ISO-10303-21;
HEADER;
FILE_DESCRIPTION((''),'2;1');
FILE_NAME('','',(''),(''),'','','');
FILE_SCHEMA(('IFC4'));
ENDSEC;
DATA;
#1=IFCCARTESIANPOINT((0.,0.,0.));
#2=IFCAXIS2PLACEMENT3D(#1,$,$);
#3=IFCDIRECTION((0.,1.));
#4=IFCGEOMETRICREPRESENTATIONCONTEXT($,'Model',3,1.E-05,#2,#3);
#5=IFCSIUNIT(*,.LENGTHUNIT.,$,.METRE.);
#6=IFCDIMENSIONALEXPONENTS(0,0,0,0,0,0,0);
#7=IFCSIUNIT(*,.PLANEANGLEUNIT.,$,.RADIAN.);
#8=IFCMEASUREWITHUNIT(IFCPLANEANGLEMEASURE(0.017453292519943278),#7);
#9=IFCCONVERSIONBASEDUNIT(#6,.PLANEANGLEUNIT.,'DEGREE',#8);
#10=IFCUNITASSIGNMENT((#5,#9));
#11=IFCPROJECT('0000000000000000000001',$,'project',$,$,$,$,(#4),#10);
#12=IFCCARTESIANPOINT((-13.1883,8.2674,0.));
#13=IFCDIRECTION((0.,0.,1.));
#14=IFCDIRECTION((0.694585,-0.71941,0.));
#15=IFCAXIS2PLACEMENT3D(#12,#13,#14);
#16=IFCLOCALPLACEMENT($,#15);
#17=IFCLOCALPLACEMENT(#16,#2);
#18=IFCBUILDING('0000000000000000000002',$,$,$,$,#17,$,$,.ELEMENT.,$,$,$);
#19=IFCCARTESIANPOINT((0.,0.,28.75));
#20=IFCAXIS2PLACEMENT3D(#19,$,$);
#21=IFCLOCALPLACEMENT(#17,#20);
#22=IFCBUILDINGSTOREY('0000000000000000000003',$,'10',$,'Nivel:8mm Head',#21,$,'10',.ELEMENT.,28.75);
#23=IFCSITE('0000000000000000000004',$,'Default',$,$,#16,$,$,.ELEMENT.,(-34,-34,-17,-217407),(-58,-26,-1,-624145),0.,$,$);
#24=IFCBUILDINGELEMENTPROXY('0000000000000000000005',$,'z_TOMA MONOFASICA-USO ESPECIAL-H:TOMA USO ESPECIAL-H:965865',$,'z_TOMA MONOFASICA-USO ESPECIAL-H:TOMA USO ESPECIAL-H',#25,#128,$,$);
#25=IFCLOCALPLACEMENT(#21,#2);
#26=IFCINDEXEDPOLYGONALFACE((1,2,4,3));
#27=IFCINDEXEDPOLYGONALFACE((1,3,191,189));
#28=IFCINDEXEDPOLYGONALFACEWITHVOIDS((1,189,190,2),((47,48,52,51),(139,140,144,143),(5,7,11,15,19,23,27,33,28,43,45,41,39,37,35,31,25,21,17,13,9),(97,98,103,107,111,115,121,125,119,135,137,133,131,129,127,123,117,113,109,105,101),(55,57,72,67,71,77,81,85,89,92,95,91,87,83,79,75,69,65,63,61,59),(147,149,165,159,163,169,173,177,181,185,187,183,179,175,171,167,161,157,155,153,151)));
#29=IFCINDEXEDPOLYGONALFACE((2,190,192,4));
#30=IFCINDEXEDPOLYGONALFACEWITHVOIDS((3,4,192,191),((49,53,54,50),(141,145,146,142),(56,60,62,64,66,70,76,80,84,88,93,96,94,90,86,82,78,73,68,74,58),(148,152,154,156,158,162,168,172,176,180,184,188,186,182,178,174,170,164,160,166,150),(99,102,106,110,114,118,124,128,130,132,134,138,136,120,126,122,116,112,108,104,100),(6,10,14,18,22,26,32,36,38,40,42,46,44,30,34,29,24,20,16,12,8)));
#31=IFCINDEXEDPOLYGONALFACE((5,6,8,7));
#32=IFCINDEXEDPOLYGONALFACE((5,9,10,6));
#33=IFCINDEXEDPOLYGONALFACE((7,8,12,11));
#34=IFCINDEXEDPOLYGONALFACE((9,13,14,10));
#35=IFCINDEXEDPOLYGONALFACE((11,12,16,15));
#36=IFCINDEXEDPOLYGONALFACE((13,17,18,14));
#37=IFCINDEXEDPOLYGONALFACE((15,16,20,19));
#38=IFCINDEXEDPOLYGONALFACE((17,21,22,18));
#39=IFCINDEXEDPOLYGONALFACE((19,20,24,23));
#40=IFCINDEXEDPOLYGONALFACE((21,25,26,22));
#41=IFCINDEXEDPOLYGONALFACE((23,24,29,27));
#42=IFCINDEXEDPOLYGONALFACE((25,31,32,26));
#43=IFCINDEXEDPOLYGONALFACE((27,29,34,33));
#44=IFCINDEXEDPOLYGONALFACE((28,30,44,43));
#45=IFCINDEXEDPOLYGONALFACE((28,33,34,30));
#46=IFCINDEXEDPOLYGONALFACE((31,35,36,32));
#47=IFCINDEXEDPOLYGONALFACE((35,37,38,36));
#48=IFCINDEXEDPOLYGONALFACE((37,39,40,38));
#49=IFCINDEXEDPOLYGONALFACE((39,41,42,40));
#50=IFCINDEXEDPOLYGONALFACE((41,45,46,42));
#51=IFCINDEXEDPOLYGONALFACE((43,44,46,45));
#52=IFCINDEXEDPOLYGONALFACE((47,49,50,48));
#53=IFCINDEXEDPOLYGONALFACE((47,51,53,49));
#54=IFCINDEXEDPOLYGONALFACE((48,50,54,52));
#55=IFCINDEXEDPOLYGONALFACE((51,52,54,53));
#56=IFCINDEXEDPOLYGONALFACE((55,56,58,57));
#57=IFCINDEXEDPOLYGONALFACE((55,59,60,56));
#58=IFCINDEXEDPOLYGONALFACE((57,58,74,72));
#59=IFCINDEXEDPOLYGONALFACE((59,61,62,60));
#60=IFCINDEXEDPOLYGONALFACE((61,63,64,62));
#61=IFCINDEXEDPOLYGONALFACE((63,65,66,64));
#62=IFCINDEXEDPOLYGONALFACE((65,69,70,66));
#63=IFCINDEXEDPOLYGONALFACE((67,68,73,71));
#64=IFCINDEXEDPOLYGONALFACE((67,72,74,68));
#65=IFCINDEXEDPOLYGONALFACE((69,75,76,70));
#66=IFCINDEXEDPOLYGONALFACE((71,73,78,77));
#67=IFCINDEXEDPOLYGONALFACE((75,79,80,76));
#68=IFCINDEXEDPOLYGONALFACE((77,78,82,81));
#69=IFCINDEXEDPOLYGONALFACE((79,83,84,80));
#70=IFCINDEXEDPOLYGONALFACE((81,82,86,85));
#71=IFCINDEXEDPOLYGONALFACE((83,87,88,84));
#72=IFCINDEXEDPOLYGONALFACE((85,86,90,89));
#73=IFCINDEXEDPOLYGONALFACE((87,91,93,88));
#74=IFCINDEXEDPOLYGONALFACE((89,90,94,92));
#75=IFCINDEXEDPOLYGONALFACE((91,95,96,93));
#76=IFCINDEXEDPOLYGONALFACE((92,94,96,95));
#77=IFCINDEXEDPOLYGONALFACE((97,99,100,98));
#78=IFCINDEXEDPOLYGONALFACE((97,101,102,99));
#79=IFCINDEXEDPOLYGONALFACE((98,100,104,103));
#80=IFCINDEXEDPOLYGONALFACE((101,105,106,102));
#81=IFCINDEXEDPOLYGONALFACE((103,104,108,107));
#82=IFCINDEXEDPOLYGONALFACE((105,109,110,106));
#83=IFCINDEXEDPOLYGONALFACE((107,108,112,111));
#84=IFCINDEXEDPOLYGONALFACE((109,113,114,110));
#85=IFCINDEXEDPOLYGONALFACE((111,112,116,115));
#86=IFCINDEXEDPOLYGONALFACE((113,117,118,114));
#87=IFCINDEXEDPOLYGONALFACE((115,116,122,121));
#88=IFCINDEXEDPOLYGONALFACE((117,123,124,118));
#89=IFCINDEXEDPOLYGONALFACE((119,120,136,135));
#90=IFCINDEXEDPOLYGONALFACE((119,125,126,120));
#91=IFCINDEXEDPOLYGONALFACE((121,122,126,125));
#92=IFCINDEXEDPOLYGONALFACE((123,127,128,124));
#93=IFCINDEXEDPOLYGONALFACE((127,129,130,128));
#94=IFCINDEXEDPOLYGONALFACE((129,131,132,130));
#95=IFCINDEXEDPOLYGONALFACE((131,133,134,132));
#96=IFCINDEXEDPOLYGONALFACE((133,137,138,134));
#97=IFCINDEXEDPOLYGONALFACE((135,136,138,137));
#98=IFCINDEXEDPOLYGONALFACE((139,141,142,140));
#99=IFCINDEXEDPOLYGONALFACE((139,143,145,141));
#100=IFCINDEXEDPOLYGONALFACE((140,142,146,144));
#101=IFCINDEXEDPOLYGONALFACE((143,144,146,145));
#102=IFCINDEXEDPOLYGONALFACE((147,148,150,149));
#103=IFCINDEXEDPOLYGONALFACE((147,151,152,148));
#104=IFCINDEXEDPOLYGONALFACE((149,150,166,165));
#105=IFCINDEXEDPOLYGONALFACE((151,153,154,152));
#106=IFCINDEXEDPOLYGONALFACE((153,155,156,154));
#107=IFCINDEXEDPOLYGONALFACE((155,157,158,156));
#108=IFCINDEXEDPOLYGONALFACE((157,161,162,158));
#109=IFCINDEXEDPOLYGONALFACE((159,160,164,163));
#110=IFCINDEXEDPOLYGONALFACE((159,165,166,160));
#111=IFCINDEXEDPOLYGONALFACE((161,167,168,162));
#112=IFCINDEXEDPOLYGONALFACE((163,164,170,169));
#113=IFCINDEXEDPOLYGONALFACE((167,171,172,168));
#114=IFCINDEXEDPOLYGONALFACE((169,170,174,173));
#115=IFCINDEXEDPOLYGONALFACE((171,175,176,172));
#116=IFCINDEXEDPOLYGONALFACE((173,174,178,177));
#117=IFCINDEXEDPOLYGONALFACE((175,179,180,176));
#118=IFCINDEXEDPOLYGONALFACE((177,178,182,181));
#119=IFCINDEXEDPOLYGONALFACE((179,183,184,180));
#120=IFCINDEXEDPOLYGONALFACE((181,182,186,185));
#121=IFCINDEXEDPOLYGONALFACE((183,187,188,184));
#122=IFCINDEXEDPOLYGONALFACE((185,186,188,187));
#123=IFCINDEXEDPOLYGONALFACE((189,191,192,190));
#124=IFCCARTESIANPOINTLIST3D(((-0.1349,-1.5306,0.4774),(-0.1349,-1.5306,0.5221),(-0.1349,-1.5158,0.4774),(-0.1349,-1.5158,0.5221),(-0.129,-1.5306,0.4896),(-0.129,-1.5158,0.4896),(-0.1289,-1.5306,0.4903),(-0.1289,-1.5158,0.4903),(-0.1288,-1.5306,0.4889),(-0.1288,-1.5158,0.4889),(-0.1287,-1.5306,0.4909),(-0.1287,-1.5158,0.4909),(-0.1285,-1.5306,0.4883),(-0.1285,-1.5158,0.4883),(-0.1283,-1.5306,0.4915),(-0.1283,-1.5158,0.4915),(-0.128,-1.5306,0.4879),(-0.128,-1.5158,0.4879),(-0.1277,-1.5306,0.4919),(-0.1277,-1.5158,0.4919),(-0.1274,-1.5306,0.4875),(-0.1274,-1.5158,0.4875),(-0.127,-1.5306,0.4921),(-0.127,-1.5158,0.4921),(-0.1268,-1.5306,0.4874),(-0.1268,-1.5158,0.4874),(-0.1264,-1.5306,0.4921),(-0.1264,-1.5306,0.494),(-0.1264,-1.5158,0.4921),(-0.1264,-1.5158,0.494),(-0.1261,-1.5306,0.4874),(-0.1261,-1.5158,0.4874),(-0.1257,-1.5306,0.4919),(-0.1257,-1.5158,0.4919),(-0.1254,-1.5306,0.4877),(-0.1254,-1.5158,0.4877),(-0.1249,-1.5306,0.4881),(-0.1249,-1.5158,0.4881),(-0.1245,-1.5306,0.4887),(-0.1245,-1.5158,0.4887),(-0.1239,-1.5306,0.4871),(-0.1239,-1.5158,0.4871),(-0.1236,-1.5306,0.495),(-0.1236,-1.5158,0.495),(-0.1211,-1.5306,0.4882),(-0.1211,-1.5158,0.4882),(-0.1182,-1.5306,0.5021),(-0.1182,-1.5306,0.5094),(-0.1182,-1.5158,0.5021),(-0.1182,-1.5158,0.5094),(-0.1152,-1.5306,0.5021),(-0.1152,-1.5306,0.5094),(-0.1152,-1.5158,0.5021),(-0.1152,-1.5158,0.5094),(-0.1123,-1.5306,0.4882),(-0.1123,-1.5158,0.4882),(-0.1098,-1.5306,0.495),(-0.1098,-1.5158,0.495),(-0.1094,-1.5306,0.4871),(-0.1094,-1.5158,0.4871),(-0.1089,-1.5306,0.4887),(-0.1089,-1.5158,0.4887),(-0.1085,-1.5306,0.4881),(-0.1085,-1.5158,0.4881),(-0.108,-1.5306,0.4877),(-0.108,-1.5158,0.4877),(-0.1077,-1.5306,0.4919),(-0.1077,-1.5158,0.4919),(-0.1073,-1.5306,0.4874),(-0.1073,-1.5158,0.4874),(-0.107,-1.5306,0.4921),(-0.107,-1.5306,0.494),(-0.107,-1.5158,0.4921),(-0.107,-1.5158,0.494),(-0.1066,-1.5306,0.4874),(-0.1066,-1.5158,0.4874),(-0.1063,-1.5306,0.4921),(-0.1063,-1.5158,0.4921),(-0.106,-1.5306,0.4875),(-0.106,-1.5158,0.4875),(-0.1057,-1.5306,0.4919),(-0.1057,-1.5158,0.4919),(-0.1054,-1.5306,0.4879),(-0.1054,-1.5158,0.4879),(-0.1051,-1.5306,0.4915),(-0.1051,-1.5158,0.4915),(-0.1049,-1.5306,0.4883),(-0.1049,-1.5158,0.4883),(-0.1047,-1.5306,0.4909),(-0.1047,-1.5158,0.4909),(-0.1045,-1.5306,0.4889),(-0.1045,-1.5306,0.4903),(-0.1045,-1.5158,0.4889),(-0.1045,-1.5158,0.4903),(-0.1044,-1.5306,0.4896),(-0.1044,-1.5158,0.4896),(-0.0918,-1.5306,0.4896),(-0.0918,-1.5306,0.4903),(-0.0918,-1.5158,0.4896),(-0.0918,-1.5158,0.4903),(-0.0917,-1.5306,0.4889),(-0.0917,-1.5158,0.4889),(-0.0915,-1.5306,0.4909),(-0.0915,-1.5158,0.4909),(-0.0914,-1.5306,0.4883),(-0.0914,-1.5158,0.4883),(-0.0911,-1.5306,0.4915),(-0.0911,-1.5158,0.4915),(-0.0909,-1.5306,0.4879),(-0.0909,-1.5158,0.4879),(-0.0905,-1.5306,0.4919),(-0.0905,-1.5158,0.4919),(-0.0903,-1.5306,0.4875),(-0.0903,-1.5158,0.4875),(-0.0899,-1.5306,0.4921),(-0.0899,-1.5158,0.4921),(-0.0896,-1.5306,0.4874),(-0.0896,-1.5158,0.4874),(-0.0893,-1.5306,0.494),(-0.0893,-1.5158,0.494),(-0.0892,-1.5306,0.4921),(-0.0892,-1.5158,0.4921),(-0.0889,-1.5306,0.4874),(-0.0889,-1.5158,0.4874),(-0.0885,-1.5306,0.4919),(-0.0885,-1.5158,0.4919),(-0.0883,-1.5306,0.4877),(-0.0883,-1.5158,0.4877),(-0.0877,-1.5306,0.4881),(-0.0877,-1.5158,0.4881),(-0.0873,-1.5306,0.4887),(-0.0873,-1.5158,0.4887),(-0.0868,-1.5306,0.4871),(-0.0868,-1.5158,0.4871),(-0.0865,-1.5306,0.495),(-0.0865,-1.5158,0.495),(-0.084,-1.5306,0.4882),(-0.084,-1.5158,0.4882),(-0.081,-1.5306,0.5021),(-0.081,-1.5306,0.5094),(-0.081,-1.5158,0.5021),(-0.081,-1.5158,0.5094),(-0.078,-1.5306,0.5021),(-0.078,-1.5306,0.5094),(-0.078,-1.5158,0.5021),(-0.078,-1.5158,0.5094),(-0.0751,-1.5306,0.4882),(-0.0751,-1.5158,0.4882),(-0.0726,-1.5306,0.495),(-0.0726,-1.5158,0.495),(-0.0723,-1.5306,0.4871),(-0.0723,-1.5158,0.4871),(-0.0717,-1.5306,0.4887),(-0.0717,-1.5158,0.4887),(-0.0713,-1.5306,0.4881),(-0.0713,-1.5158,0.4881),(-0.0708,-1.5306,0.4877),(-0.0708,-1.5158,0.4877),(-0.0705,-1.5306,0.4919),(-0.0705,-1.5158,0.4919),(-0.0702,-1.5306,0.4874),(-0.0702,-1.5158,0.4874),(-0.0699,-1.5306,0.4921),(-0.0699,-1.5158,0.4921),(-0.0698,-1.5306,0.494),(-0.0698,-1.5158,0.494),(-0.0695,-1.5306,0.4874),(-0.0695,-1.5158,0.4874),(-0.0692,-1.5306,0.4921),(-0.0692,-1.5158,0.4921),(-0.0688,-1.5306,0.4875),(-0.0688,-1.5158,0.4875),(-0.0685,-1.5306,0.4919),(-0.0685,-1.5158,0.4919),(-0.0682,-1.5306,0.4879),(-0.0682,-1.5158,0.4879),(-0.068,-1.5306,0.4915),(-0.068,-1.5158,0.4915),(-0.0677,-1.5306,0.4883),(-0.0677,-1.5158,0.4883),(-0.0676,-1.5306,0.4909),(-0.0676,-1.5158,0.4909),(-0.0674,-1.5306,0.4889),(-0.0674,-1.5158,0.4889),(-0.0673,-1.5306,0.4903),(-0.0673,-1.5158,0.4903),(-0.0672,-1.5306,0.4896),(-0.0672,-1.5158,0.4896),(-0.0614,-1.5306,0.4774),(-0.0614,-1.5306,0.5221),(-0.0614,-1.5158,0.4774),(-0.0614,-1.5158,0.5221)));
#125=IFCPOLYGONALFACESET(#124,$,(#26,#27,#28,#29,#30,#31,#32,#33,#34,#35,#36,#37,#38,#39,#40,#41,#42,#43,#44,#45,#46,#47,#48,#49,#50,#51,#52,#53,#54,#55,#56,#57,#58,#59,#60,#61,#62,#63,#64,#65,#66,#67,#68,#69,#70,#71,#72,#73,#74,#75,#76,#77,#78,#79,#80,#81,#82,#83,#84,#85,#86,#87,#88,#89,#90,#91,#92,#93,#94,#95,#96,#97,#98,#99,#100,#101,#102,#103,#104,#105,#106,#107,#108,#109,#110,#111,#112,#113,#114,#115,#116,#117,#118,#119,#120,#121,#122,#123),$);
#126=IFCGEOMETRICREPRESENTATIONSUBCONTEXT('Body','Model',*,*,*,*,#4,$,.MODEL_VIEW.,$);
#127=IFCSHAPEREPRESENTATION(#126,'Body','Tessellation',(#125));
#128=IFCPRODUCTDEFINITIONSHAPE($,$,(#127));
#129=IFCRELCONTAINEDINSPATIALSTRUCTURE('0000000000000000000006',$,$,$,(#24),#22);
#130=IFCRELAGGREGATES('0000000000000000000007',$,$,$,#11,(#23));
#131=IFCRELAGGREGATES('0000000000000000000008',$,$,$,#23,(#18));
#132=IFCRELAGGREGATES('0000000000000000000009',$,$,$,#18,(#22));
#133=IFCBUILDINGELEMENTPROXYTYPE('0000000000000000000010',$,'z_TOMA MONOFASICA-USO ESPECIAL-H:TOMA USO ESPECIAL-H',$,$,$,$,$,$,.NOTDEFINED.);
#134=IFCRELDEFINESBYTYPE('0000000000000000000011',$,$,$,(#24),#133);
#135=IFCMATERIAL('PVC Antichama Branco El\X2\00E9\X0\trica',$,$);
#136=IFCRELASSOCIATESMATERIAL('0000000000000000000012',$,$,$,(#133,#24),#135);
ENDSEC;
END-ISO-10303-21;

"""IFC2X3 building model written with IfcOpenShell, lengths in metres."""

from ifc_helpers import new_model, entity, si_unit, converted_unit, direction, frame, frame_2d, origin, place, context, subcontext, project, spatial, polyline, circle_curve, parameter, trimmed, segment, composite_curve, outline, extrude, source, transform, mapped, material, type_object, type_shapes, element, save


model = new_model("IFC2X3")

# Units and contexts
model_context = context("Model", 3, precision=1e-05, world=origin(), true_north=direction((0.0, 1.0)))
body_context = subcontext(model_context, "Body", "Model", "MODEL_VIEW")
ifc_project = project(units=[si_unit("LENGTHUNIT", "METRE"), converted_unit("PLANEANGLEUNIT", "DEGREE", entity("IfcPlaneAngleMeasure", 0.017453292519943278), si_unit("PLANEANGLEUNIT", "RADIAN"), dimensions=[0, 0, 0, 0, 0, 0, 0])], contexts=[model_context])

# Site, building, storey
site_placement = place(None, frame((-13.1883, 8.2674, 0.0), z_axis=(0.0, 0.0, 1.0), x_axis=(0.694585, -0.71941, 0.0)))
site = spatial("IfcSite", under=ifc_project, at=site_placement, Name="Default", CompositionType="ELEMENT", RefLatitude=(-34, -34, -17, -217407), RefLongitude=(-58, -26, -1, -624145), RefElevation=0.0)
building_placement = place(site_placement, origin())
building = spatial("IfcBuilding", under=site, at=building_placement, CompositionType="ELEMENT")
storey_placement = place(building_placement, frame((0.0, 0.0, 28.75)))
storey = spatial("IfcBuildingStorey", under=building, at=storey_placement, Name="10", ObjectType="Nivel:8mm Head", LongName="10", CompositionType="ELEMENT", Elevation=28.75)

# Building element proxy
ifc_material_1 = material(Name="PVC Antichama Branco Elétrica")
building_element_proxy_type_1 = type_object("IfcBuildingElementProxyType", Name="z_TOMA MONOFASICA-USO ESPECIAL-H:TOMA USO ESPECIAL-H", PredefinedType="NOTDEFINED", material=ifc_material_1)
shared_shape_1 = source(origin(), body_context, "Body", "SweptSolid", [
    extrude(outline(polyline([(-0.0368, -0.0223), (0.0368, -0.0223), (0.0368, 0.0223), (-0.0368, 0.0223), (-0.0368, -0.0223)]), holes=[composite_curve([segment(polyline([(0.0141, 0.0115), (0.0116, 0.0047)]), True, "CONTINUOUS"), segment(polyline([(0.0116, 0.0047), (0.0088, 0.0057)]), True, "CONTINUOUS"), segment(polyline([(0.0088, 0.0057), (0.0096, 0.0078)]), True, "CONTINUOUS"), segment(trimmed(circle_curve(frame_2d((0.0087, 0.0099), x_axis=(1.0, 0.0)), 0.0024), [parameter(27.118901)], [parameter(292.881099)], True, "PARAMETER"), False, "CONTINUOUS"), segment(polyline([(0.0108, 0.011), (0.0113, 0.0126)]), True, "CONTINUOUS"), segment(polyline([(0.0113, 0.0126), (0.0141, 0.0115)]), True, "CONTINUOUS")], self_intersect=False), composite_curve([segment(polyline([(0.0255, 0.0047), (0.023, 0.0115)]), True, "CONTINUOUS"), segment(polyline([(0.023, 0.0115), (0.0258, 0.0126)]), True, "CONTINUOUS"), segment(polyline([(0.0258, 0.0126), (0.0264, 0.011)]), True, "CONTINUOUS"), segment(trimmed(circle_curve(frame_2d((0.0285, 0.0099), x_axis=(1.0, 0.0)), 0.0024), [parameter(247.118901)], [parameter(152.881099)], True, "PARAMETER"), False, "CONTINUOUS"), segment(polyline([(0.0276, 0.0078), (0.0283, 0.0057)]), True, "CONTINUOUS"), segment(polyline([(0.0283, 0.0057), (0.0255, 0.0047)]), True, "CONTINUOUS")], self_intersect=False), polyline([(0.0201, -0.0024), (0.0201, -0.0097), (0.0171, -0.0097), (0.0171, -0.0024), (0.0201, -0.0024)]), composite_curve([segment(polyline([(-0.0141, 0.0115), (-0.0113, 0.0126)]), True, "CONTINUOUS"), segment(polyline([(-0.0113, 0.0126), (-0.0108, 0.011)]), True, "CONTINUOUS"), segment(trimmed(circle_curve(frame_2d((-0.0087, 0.0099), x_axis=(1.0, 0.0)), 0.0024), [parameter(247.118901)], [parameter(152.881099)], True, "PARAMETER"), False, "CONTINUOUS"), segment(polyline([(-0.0096, 0.0078), (-0.0088, 0.0057)]), True, "CONTINUOUS"), segment(polyline([(-0.0088, 0.0057), (-0.0116, 0.0047)]), True, "CONTINUOUS"), segment(polyline([(-0.0116, 0.0047), (-0.0141, 0.0115)]), True, "CONTINUOUS")], self_intersect=False), composite_curve([segment(polyline([(-0.0255, 0.0047), (-0.0283, 0.0057)]), True, "CONTINUOUS"), segment(polyline([(-0.0283, 0.0057), (-0.0276, 0.0078)]), True, "CONTINUOUS"), segment(trimmed(circle_curve(frame_2d((-0.0285, 0.0099), x_axis=(1.0, 0.0)), 0.0024), [parameter(27.118901)], [parameter(292.881099)], True, "PARAMETER"), False, "CONTINUOUS"), segment(polyline([(-0.0264, 0.011), (-0.0258, 0.0126)]), True, "CONTINUOUS"), segment(polyline([(-0.0258, 0.0126), (-0.023, 0.0115)]), True, "CONTINUOUS"), segment(polyline([(-0.023, 0.0115), (-0.0255, 0.0047)]), True, "CONTINUOUS")], self_intersect=False), polyline([(-0.0201, -0.0024), (-0.0171, -0.0024), (-0.0171, -0.0097), (-0.0201, -0.0097), (-0.0201, -0.0024)])]), frame((0.0, -0.005, 0.0223), z_axis=(0.0, 1.0, 0.0), x_axis=(1.0, 0.0, 0.0)), (0.0, 0.0, 1.0), 0.0148),
])
type_shapes(building_element_proxy_type_1, [shared_shape_1])
proxy_1_placement = place(storey_placement, frame((-0.0981, -1.5256, 0.4774)))
element("IfcBuildingElementProxy", 1, at=proxy_1_placement, inside=storey, type_object=building_element_proxy_type_1, material=ifc_material_1, Name="z_TOMA MONOFASICA-USO ESPECIAL-H:TOMA USO ESPECIAL-H:965865", ObjectType="z_TOMA MONOFASICA-USO ESPECIAL-H:TOMA USO ESPECIAL-H", context=body_context, shape_type="MappedRepresentation", body=[
    mapped(shared_shape_1, transform((0.0, 0.0, 0.0), scale=1.0)),
])

save(model, "model.ifc")
